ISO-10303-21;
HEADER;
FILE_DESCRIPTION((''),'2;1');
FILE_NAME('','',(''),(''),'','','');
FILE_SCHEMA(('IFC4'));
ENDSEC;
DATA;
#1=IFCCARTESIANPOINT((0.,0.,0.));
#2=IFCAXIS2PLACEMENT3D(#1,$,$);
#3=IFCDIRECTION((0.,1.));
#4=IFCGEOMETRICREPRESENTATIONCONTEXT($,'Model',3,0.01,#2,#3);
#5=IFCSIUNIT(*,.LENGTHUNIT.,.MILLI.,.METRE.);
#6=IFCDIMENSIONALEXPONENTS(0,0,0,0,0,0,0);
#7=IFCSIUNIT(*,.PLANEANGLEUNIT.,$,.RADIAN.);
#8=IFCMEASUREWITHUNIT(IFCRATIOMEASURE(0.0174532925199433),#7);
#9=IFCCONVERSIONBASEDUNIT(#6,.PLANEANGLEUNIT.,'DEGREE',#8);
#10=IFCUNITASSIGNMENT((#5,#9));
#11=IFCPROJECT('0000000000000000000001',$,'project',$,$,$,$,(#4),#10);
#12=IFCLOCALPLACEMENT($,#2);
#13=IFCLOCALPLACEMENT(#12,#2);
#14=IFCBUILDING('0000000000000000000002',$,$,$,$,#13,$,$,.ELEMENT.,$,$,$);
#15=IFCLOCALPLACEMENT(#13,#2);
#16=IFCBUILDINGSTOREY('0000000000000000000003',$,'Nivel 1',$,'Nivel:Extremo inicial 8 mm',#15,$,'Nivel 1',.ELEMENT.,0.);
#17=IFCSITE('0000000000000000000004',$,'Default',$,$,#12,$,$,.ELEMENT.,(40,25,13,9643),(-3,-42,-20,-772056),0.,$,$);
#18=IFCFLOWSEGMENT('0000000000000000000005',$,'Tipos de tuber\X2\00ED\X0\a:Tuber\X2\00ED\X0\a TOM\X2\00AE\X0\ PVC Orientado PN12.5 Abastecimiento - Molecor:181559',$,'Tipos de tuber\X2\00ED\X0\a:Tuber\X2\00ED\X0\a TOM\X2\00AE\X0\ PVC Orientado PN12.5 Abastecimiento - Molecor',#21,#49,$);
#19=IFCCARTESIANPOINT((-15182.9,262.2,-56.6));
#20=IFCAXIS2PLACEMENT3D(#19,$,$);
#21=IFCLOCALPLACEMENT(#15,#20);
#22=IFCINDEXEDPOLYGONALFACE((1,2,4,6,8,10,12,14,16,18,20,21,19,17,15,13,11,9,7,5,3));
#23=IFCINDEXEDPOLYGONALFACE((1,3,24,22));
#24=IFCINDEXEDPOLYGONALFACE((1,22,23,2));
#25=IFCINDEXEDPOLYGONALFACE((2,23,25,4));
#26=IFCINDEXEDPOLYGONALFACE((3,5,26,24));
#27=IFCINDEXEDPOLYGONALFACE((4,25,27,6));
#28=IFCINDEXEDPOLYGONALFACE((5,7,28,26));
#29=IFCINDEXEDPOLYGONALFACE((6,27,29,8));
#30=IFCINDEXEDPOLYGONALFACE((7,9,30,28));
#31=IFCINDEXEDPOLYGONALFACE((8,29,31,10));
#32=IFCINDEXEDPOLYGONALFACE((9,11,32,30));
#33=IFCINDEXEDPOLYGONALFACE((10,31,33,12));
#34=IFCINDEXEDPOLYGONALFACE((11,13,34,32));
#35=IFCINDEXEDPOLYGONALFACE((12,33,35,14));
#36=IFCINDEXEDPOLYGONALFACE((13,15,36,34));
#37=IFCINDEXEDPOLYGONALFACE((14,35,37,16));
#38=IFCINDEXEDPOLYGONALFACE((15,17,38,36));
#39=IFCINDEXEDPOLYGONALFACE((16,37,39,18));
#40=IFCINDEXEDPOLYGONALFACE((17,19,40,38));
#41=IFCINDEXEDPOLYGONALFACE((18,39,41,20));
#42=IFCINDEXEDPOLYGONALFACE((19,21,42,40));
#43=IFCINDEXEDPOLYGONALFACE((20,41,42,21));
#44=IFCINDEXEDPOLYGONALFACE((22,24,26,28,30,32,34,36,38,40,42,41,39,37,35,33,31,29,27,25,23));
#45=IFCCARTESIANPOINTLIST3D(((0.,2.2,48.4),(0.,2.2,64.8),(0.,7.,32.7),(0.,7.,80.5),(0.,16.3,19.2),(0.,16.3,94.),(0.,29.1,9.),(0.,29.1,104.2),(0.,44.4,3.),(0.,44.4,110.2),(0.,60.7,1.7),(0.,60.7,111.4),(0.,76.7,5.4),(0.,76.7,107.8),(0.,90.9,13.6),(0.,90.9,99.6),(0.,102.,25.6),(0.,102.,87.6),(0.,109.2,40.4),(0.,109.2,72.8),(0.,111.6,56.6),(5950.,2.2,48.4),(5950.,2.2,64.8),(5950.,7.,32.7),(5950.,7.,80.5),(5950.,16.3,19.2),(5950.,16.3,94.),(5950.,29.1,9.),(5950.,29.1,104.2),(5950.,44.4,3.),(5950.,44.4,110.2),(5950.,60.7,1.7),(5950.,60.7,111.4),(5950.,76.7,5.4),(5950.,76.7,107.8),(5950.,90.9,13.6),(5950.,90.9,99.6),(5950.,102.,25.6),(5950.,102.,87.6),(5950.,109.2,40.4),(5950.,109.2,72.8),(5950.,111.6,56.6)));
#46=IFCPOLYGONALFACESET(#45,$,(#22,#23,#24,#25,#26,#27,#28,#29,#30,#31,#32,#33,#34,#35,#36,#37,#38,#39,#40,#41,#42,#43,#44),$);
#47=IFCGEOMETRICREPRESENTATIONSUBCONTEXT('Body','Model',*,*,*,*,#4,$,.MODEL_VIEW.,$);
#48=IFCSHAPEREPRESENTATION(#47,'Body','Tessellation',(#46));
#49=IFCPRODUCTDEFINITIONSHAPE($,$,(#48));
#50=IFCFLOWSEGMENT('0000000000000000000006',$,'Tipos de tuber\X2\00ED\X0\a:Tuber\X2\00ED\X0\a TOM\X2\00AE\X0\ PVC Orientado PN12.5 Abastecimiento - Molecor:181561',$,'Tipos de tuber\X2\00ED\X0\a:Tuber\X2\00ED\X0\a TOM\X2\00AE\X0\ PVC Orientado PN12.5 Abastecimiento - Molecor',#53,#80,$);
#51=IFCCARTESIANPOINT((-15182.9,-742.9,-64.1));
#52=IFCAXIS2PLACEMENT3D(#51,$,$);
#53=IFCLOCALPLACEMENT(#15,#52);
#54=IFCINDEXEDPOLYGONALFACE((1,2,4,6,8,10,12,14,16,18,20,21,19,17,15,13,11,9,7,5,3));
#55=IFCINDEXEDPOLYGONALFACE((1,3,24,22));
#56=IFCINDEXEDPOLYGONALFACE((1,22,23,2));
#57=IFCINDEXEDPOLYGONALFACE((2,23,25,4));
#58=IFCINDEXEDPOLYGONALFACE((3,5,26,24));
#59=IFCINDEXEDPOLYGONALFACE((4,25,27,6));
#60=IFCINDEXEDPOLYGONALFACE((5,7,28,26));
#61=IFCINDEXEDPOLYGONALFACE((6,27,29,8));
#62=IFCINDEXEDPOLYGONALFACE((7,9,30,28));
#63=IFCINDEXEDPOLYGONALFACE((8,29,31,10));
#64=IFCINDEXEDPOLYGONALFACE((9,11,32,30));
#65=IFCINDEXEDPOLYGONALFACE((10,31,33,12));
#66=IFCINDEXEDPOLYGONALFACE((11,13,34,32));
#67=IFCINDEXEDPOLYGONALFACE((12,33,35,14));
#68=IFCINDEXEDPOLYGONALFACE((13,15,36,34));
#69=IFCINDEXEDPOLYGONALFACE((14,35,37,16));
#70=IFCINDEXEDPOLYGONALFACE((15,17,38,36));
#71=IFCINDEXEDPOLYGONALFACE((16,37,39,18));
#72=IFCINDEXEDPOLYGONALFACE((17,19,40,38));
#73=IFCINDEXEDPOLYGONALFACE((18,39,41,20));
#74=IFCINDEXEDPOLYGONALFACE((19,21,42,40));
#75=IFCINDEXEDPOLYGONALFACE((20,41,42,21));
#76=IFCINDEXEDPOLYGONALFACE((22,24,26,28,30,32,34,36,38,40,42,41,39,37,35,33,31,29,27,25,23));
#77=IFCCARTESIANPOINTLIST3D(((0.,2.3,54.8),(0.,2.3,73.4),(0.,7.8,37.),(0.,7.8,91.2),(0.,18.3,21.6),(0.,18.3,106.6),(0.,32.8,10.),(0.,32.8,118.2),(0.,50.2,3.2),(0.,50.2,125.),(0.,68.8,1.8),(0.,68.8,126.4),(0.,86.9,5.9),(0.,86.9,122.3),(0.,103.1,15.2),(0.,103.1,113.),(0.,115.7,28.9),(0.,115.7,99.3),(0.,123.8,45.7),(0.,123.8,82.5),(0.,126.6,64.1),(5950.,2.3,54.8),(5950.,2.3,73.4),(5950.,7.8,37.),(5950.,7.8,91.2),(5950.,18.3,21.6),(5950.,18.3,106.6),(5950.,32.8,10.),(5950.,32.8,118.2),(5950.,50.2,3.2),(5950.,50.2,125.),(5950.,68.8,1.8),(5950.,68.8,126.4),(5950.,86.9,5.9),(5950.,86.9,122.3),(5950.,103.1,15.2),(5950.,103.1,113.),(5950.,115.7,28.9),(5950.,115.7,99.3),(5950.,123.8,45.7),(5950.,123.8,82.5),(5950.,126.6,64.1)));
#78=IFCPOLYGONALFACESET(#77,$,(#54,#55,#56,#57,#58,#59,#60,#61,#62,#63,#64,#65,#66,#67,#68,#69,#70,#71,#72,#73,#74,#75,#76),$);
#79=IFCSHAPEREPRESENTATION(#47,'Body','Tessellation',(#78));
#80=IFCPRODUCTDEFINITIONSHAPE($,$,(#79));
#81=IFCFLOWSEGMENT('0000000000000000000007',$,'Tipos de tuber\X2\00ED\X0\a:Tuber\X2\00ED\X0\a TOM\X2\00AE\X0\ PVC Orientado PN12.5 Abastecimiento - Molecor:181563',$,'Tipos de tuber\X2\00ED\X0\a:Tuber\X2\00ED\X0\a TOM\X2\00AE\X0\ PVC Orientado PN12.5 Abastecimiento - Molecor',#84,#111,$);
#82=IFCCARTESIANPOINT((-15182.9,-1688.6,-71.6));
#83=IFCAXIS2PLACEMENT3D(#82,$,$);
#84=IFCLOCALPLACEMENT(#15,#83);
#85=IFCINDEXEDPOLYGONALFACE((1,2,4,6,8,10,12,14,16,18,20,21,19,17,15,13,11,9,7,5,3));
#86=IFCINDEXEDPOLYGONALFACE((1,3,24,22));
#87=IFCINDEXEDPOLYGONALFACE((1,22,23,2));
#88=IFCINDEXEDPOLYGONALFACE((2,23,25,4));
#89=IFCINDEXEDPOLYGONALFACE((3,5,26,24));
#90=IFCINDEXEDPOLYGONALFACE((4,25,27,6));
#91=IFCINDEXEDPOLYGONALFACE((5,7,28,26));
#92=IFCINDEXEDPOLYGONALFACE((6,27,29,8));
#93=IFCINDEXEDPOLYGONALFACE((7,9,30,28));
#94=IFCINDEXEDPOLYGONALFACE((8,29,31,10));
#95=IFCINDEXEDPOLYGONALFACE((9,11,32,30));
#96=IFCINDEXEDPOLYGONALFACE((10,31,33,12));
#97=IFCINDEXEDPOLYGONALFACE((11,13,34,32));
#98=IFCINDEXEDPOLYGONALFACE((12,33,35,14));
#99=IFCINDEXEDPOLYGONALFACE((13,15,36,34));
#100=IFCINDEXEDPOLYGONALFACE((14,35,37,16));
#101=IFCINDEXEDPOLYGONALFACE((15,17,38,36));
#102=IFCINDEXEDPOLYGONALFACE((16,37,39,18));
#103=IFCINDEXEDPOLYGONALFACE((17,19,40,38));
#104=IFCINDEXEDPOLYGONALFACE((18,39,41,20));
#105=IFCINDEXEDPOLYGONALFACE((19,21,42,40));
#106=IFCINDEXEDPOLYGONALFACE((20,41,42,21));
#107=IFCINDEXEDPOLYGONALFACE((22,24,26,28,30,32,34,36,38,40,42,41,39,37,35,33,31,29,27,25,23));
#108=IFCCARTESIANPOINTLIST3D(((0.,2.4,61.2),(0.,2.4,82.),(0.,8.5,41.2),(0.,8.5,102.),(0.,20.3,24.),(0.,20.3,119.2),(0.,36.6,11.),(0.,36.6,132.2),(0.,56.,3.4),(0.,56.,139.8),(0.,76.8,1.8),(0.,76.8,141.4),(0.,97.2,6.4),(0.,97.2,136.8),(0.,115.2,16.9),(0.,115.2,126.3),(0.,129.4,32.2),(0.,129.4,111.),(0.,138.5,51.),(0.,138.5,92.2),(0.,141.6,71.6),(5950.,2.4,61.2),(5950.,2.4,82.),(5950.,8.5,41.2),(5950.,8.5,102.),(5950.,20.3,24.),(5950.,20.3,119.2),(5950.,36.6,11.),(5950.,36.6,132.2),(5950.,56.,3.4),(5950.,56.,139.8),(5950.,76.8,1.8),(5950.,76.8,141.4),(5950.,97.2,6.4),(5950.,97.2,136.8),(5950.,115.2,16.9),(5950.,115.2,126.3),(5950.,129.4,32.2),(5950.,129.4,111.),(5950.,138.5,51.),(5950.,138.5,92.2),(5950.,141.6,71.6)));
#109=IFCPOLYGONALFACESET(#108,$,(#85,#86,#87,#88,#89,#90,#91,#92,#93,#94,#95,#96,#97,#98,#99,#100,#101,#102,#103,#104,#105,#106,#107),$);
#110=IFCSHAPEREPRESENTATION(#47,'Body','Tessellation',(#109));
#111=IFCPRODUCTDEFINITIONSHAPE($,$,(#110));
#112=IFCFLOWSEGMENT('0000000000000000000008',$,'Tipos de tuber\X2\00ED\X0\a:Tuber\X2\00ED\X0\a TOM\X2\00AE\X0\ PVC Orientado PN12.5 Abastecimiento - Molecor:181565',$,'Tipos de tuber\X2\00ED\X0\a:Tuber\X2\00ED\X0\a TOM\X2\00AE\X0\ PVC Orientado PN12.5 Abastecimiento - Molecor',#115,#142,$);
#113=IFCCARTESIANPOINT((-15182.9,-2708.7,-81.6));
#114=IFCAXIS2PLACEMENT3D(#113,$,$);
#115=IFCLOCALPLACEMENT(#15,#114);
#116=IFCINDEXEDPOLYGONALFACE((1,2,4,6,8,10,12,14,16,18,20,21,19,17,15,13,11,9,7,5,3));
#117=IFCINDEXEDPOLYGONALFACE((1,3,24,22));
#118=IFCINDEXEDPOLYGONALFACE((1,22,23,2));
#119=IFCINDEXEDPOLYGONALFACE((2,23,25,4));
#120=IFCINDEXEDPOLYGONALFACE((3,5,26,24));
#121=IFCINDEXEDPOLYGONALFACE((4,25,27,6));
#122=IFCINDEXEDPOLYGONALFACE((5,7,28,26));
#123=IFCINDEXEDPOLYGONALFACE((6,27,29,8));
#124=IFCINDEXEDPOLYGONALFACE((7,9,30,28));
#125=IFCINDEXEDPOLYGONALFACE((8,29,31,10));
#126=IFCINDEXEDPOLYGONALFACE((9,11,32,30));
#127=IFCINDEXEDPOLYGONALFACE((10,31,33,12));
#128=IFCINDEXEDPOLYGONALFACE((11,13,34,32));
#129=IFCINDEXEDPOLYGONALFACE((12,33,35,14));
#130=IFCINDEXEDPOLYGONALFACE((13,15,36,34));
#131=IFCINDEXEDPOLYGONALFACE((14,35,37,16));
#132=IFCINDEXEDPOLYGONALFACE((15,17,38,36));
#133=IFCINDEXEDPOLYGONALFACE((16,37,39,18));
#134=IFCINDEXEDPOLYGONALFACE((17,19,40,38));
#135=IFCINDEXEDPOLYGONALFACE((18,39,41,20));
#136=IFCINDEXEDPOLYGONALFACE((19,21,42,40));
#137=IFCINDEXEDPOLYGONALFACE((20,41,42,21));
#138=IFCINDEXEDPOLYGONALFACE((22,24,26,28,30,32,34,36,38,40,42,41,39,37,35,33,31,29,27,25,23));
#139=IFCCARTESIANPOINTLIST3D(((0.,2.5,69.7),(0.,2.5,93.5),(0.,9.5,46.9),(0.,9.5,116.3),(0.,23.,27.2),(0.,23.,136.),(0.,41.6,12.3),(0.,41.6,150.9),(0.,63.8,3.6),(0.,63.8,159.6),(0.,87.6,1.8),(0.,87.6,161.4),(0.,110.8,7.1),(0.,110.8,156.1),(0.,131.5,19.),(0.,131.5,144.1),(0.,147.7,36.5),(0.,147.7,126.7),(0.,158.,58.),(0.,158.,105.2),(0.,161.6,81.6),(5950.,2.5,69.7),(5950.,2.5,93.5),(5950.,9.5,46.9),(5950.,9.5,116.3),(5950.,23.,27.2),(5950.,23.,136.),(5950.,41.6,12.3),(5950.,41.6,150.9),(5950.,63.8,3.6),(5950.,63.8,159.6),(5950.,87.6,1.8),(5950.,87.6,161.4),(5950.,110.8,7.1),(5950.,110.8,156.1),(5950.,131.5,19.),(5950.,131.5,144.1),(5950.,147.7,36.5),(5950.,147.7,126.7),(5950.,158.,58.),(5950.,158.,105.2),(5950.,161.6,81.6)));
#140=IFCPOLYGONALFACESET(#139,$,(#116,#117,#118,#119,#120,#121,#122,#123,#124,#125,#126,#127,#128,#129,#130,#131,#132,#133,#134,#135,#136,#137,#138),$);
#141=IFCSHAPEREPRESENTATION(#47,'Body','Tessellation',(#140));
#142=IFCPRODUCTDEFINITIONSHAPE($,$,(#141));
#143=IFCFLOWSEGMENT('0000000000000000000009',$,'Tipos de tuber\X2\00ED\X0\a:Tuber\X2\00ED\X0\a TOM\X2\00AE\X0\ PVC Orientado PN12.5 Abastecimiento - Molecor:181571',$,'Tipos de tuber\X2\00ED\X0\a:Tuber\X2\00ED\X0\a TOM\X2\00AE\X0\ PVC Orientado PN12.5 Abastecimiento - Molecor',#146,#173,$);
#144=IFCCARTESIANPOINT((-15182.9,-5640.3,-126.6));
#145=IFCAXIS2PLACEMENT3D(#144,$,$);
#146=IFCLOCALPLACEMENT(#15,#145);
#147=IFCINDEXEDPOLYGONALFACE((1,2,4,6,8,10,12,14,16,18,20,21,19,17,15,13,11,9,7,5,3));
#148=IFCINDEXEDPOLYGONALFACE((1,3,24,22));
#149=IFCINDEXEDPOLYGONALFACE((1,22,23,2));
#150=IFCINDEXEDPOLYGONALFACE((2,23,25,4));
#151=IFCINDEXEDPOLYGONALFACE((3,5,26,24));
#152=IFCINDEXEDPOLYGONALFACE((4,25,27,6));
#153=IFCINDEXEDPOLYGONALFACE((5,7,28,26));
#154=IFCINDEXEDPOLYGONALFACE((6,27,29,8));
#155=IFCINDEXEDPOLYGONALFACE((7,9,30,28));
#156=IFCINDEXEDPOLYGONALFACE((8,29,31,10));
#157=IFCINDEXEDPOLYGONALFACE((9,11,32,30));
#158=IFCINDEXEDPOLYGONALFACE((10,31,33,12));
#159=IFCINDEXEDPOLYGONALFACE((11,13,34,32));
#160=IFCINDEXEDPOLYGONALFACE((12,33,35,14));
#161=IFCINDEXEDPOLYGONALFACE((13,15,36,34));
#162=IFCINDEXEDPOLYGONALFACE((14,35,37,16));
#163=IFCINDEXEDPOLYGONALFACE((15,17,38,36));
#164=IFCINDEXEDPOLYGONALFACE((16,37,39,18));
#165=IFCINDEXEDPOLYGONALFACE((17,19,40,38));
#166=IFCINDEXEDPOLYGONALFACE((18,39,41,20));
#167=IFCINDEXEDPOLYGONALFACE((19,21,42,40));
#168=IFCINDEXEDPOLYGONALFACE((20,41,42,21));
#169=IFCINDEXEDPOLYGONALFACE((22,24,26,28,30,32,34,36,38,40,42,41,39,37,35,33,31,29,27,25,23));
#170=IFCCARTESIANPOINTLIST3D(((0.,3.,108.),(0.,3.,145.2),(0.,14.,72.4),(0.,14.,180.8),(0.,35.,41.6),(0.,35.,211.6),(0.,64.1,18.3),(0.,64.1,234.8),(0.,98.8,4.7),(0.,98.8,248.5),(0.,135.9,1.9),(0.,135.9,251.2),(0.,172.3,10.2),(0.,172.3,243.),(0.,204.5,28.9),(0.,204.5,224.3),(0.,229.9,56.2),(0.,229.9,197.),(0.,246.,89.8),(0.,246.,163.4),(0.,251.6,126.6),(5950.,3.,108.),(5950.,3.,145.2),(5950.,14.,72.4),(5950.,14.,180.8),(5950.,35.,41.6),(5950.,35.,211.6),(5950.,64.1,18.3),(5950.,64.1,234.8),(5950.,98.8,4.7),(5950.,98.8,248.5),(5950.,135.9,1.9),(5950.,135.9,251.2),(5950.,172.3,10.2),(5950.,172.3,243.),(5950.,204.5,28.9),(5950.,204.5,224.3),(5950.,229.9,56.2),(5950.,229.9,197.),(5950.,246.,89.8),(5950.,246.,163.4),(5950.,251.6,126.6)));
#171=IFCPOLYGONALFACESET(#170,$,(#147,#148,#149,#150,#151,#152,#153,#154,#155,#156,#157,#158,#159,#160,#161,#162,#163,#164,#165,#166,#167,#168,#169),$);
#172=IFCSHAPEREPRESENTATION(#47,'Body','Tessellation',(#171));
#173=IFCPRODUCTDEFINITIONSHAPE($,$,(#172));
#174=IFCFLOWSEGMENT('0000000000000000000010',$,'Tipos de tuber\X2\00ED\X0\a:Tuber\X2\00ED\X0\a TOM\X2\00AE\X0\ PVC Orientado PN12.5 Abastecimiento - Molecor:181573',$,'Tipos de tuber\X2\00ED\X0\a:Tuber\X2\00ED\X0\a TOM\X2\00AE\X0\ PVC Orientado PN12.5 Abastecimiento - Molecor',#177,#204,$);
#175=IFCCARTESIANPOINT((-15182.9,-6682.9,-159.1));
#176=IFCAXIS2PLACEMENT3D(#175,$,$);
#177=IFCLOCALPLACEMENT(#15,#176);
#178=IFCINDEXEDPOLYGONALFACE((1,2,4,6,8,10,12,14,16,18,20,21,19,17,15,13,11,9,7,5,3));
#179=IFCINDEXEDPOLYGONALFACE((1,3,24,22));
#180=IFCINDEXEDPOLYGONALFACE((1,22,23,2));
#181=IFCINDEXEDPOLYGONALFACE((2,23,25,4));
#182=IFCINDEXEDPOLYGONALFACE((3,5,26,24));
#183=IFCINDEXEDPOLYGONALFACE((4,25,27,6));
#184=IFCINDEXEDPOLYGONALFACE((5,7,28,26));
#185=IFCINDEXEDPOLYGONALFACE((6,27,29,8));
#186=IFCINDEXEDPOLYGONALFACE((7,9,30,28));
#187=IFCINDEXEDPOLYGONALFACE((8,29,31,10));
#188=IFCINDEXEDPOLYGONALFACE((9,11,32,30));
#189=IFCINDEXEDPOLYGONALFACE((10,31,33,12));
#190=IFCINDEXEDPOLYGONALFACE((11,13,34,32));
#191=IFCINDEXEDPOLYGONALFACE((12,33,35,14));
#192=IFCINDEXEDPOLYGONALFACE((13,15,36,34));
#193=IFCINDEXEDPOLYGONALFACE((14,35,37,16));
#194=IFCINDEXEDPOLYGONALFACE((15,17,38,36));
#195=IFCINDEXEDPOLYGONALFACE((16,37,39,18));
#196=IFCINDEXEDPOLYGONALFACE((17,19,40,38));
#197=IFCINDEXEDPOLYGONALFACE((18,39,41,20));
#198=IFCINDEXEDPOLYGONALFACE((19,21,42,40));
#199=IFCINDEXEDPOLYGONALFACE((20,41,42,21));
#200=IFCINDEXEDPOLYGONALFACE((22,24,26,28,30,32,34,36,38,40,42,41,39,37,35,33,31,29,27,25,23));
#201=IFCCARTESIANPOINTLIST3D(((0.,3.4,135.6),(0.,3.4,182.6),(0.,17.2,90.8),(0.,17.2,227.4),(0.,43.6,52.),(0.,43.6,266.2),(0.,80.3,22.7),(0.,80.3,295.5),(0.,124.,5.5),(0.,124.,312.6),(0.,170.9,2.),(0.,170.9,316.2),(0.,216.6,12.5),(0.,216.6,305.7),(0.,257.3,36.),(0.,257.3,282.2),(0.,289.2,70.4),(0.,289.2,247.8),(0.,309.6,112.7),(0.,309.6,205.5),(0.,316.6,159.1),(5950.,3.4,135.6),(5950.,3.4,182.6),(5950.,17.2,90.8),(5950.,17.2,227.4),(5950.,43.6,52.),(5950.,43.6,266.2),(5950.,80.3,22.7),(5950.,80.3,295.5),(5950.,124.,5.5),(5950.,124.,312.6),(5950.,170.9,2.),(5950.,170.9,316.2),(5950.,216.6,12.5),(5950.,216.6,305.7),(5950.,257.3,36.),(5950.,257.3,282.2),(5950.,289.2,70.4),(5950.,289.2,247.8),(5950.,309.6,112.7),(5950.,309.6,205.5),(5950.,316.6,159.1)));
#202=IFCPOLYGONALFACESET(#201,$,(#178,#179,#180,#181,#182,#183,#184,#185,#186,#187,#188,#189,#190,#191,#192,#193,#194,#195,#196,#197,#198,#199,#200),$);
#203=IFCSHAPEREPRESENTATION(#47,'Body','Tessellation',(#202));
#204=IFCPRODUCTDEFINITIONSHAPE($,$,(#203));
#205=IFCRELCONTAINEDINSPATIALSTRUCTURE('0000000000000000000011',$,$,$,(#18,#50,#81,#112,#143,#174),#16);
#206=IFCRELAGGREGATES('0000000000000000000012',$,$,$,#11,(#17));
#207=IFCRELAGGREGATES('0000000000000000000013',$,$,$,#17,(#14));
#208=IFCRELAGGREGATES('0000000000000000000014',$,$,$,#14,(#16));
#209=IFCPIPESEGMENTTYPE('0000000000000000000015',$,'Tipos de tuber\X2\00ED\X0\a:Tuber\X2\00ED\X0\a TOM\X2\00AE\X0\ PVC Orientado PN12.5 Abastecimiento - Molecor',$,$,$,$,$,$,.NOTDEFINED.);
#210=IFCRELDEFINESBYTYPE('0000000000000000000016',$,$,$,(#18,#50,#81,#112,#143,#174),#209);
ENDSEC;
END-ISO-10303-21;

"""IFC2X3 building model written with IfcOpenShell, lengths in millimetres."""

from ifc_helpers import new_model, entity, si_unit, converted_unit, direction, frame, frame_2d, origin, place, context, subcontext, project, spatial, circle, extrude, type_object, element, save


model = new_model("IFC2X3")

# Units and contexts
model_context = context("Model", 3, precision=0.01, world=origin(), true_north=direction((0.0, 1.0)))
body_context = subcontext(model_context, "Body", "Model", "MODEL_VIEW")
ifc_project = project(units=[si_unit("LENGTHUNIT", "METRE", prefix="MILLI"), converted_unit("PLANEANGLEUNIT", "DEGREE", entity("IfcRatioMeasure", 0.0174532925199433), si_unit("PLANEANGLEUNIT", "RADIAN"), dimensions=[0, 0, 0, 0, 0, 0, 0])], contexts=[model_context])

# Site, building, storey
site_placement = place(None, origin())
site = spatial("IfcSite", under=ifc_project, at=site_placement, Name="Default", CompositionType="ELEMENT", RefLatitude=(40, 25, 13, 9643), RefLongitude=(-3, -42, -20, -772056), RefElevation=0.0)
building_placement = place(site_placement, origin())
building = spatial("IfcBuilding", under=site, at=building_placement, CompositionType="ELEMENT")
storey_placement = place(building_placement, origin())
storey = spatial("IfcBuildingStorey", under=building, at=storey_placement, Name="Nivel 1", ObjectType="Nivel:Extremo inicial 8 mm", LongName="Nivel 1", CompositionType="ELEMENT", Elevation=0.0)

# Flow segments
pipe_segment_type = type_object("IfcPipeSegmentType", Name="Tipos de tubería:Tubería TOM® PVC Orientado PN12.5 Abastecimiento - Molecor", PredefinedType="NOTDEFINED")
flow_segment_1_placement = place(storey_placement, frame((-15182.9, 262.2, -56.6)))
element("IfcFlowSegment", 1, at=flow_segment_1_placement, inside=storey, type_object=pipe_segment_type, Name="Tipos de tubería:Tubería TOM® PVC Orientado PN12.5 Abastecimiento - Molecor:181559", ObjectType="Tipos de tubería:Tubería TOM® PVC Orientado PN12.5 Abastecimiento - Molecor", context=body_context, shape_type="SweptSolid", body=[
    extrude(circle(Radius=55.0, at=frame_2d((0.0, 0.0), x_axis=(1.0, 0.0))), frame((0.0, 56.6, 56.6), z_axis=(1.0, 0.0, 0.0), x_axis=(0.0, 1.0, 0.0)), (0.0, 0.0, 1.0), 5950.0),
])
flow_segment_2_placement = place(storey_placement, frame((-15182.9, -742.9, -64.1)))
element("IfcFlowSegment", 2, at=flow_segment_2_placement, inside=storey, type_object=pipe_segment_type, Name="Tipos de tubería:Tubería TOM® PVC Orientado PN12.5 Abastecimiento - Molecor:181561", ObjectType="Tipos de tubería:Tubería TOM® PVC Orientado PN12.5 Abastecimiento - Molecor", context=body_context, shape_type="SweptSolid", body=[
    extrude(circle(Radius=62.5, at=frame_2d((0.0, 0.0), x_axis=(1.0, 0.0))), frame((0.0, 64.1, 64.1), z_axis=(1.0, 0.0, 0.0), x_axis=(0.0, 1.0, 0.0)), (0.0, 0.0, 1.0), 5950.0),
])
flow_segment_3_placement = place(storey_placement, frame((-15182.9, -1688.6, -71.6)))
element("IfcFlowSegment", 3, at=flow_segment_3_placement, inside=storey, type_object=pipe_segment_type, Name="Tipos de tubería:Tubería TOM® PVC Orientado PN12.5 Abastecimiento - Molecor:181563", ObjectType="Tipos de tubería:Tubería TOM® PVC Orientado PN12.5 Abastecimiento - Molecor", context=body_context, shape_type="SweptSolid", body=[
    extrude(circle(Radius=70.0, at=frame_2d((0.0, 0.0), x_axis=(1.0, 0.0))), frame((0.0, 71.6, 71.6), z_axis=(1.0, 0.0, 0.0), x_axis=(0.0, 1.0, 0.0)), (0.0, 0.0, 1.0), 5950.0),
])
flow_segment_4_placement = place(storey_placement, frame((-15182.9, -2708.7, -81.6)))
element("IfcFlowSegment", 4, at=flow_segment_4_placement, inside=storey, type_object=pipe_segment_type, Name="Tipos de tubería:Tubería TOM® PVC Orientado PN12.5 Abastecimiento - Molecor:181565", ObjectType="Tipos de tubería:Tubería TOM® PVC Orientado PN12.5 Abastecimiento - Molecor", context=body_context, shape_type="SweptSolid", body=[
    extrude(circle(Radius=80.0, at=frame_2d((0.0, 0.0), x_axis=(1.0, 0.0))), frame((0.0, 81.6, 81.6), z_axis=(1.0, 0.0, 0.0), x_axis=(0.0, 1.0, 0.0)), (0.0, 0.0, 1.0), 5950.0),
])
flow_segment_5_placement = place(storey_placement, frame((-15182.9, -5640.3, -126.6)))
element("IfcFlowSegment", 5, at=flow_segment_5_placement, inside=storey, type_object=pipe_segment_type, Name="Tipos de tubería:Tubería TOM® PVC Orientado PN12.5 Abastecimiento - Molecor:181571", ObjectType="Tipos de tubería:Tubería TOM® PVC Orientado PN12.5 Abastecimiento - Molecor", context=body_context, shape_type="SweptSolid", body=[
    extrude(circle(Radius=125.0, at=frame_2d((0.0, 0.0), x_axis=(1.0, 0.0))), frame((0.0, 126.6, 126.6), z_axis=(1.0, 0.0, 0.0), x_axis=(0.0, 1.0, 0.0)), (0.0, 0.0, 1.0), 5950.0),
])
flow_segment_6_placement = place(storey_placement, frame((-15182.9, -6682.9, -159.1)))
element("IfcFlowSegment", 6, at=flow_segment_6_placement, inside=storey, type_object=pipe_segment_type, Name="Tipos de tubería:Tubería TOM® PVC Orientado PN12.5 Abastecimiento - Molecor:181573", ObjectType="Tipos de tubería:Tubería TOM® PVC Orientado PN12.5 Abastecimiento - Molecor", context=body_context, shape_type="SweptSolid", body=[
    extrude(circle(Radius=157.5, at=frame_2d((0.0, 0.0), x_axis=(1.0, 0.0))), frame((0.0, 159.1, 159.1), z_axis=(1.0, 0.0, 0.0), x_axis=(0.0, 1.0, 0.0)), (0.0, 0.0, 1.0), 5950.0),
])

save(model, "model.ifc")
